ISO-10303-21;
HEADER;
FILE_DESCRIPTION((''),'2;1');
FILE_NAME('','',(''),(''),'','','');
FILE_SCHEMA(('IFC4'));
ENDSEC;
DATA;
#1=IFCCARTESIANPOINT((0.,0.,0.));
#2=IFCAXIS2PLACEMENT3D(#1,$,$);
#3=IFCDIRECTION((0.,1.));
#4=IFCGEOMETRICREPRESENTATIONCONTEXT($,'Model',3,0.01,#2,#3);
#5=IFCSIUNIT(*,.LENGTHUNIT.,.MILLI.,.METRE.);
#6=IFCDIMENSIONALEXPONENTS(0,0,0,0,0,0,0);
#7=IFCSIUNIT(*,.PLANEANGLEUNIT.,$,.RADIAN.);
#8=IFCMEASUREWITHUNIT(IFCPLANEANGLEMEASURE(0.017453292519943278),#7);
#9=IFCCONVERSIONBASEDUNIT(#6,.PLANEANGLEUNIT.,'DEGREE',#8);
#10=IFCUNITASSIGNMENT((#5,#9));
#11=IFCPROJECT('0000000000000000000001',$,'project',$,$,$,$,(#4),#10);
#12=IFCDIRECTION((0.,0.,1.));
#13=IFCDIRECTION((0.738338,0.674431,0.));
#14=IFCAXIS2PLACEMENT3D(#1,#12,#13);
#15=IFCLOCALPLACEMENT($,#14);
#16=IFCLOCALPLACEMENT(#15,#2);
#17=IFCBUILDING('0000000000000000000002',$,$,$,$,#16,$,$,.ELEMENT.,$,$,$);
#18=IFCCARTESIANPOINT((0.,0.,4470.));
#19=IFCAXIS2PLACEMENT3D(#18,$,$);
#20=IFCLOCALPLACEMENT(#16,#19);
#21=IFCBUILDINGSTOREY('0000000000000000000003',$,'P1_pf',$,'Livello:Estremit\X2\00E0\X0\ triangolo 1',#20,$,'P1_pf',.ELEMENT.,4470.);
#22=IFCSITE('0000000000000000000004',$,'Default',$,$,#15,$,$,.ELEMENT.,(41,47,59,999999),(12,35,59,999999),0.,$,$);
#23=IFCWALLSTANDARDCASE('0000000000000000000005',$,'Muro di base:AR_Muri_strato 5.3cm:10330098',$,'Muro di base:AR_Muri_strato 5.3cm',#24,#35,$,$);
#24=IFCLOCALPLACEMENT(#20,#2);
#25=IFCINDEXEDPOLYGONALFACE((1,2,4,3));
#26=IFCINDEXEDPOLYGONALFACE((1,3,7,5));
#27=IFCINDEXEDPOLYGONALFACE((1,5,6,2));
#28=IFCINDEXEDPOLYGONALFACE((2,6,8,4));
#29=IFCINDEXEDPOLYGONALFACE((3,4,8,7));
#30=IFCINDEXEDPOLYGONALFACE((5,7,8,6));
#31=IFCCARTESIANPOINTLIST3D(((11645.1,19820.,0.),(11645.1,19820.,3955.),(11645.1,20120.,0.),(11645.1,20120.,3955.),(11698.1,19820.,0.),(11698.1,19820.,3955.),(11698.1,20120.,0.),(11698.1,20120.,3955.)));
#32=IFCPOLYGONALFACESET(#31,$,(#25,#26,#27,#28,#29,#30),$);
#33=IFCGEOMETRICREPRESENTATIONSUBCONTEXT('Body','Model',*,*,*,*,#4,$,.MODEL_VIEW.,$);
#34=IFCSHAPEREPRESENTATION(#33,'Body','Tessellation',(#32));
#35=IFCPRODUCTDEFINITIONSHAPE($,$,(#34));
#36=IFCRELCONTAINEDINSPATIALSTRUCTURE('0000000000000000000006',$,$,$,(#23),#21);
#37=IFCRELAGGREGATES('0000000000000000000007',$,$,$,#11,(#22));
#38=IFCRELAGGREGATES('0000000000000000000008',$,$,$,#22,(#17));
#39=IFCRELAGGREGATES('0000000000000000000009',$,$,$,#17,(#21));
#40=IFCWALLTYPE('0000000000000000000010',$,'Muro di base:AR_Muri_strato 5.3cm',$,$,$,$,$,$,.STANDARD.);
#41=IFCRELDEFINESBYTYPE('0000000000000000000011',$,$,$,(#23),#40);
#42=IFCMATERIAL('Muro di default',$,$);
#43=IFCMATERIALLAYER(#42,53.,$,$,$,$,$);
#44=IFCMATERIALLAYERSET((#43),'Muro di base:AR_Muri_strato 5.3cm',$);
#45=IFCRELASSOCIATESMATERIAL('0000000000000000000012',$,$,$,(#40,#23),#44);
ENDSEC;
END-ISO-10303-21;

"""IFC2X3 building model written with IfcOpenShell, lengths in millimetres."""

from ifc_helpers import new_model, entity, si_unit, converted_unit, direction, frame, frame_2d, origin, place, context, subcontext, project, spatial, rectangle, extrude, material, layer, layer_set, layer_usage, type_object, element, save


model = new_model("IFC2X3")

# Units and contexts
model_context = context("Model", 3, precision=0.01, world=origin(), true_north=direction((0.0, 1.0)))
body_context = subcontext(model_context, "Body", "Model", "MODEL_VIEW")
ifc_project = project(units=[si_unit("LENGTHUNIT", "METRE", prefix="MILLI"), converted_unit("PLANEANGLEUNIT", "DEGREE", entity("IfcPlaneAngleMeasure", 0.017453292519943278), si_unit("PLANEANGLEUNIT", "RADIAN"), dimensions=[0, 0, 0, 0, 0, 0, 0])], contexts=[model_context])

# Site, building, storey
site_placement = place(None, frame((0.0, 0.0, 0.0), z_axis=(0.0, 0.0, 1.0), x_axis=(0.738338, 0.674431, 0.0)))
site = spatial("IfcSite", under=ifc_project, at=site_placement, Name="Default", CompositionType="ELEMENT", RefLatitude=(41, 47, 59, 999999), RefLongitude=(12, 35, 59, 999999), RefElevation=0.0)
building_placement = place(site_placement, origin())
building = spatial("IfcBuilding", under=site, at=building_placement, CompositionType="ELEMENT")
storey_placement = place(building_placement, frame((0.0, 0.0, 4470.0)))
storey = spatial("IfcBuildingStorey", under=building, at=storey_placement, Name="P1_pf", ObjectType="Livello:Estremità triangolo 1", LongName="P1_pf", CompositionType="ELEMENT", Elevation=4470.0)

# Shared definitions
ifc_material_1 = material(Name="Muro di default")

# Wall
ifc_layer_1 = layer(ifc_material_1, 53.0)
ifc_layer_set_1 = layer_set([ifc_layer_1], Name="Muro di base:AR_Muri_strato 5.3cm")
ifc_layer_usage_1 = layer_usage(ifc_layer_set_1, "AXIS2", "NEGATIVE", 26.5)
wall_type_1 = type_object("IfcWallType", Name="Muro di base:AR_Muri_strato 5.3cm", PredefinedType="STANDARD", material=ifc_layer_set_1)
wall_1_placement = place(storey_placement, frame((11671.6, 20120.0, 0.0), z_axis=(0.0, 0.0, 1.0), x_axis=(0.0, -1.0, 0.0)))
element("IfcWallStandardCase", 1, at=wall_1_placement, inside=storey, type_object=wall_type_1, material=ifc_layer_usage_1, Name="Muro di base:AR_Muri_strato 5.3cm:10330098", ObjectType="Muro di base:AR_Muri_strato 5.3cm", context=body_context, shape_type="SweptSolid", body=[
    extrude(rectangle(XDim=300.0, YDim=53.0, at=frame_2d((150.0, 0.0), x_axis=(-1.0, 0.0))), origin(), (0.0, 0.0, 1.0), 3955.0),
])

save(model, "model.ifc")
